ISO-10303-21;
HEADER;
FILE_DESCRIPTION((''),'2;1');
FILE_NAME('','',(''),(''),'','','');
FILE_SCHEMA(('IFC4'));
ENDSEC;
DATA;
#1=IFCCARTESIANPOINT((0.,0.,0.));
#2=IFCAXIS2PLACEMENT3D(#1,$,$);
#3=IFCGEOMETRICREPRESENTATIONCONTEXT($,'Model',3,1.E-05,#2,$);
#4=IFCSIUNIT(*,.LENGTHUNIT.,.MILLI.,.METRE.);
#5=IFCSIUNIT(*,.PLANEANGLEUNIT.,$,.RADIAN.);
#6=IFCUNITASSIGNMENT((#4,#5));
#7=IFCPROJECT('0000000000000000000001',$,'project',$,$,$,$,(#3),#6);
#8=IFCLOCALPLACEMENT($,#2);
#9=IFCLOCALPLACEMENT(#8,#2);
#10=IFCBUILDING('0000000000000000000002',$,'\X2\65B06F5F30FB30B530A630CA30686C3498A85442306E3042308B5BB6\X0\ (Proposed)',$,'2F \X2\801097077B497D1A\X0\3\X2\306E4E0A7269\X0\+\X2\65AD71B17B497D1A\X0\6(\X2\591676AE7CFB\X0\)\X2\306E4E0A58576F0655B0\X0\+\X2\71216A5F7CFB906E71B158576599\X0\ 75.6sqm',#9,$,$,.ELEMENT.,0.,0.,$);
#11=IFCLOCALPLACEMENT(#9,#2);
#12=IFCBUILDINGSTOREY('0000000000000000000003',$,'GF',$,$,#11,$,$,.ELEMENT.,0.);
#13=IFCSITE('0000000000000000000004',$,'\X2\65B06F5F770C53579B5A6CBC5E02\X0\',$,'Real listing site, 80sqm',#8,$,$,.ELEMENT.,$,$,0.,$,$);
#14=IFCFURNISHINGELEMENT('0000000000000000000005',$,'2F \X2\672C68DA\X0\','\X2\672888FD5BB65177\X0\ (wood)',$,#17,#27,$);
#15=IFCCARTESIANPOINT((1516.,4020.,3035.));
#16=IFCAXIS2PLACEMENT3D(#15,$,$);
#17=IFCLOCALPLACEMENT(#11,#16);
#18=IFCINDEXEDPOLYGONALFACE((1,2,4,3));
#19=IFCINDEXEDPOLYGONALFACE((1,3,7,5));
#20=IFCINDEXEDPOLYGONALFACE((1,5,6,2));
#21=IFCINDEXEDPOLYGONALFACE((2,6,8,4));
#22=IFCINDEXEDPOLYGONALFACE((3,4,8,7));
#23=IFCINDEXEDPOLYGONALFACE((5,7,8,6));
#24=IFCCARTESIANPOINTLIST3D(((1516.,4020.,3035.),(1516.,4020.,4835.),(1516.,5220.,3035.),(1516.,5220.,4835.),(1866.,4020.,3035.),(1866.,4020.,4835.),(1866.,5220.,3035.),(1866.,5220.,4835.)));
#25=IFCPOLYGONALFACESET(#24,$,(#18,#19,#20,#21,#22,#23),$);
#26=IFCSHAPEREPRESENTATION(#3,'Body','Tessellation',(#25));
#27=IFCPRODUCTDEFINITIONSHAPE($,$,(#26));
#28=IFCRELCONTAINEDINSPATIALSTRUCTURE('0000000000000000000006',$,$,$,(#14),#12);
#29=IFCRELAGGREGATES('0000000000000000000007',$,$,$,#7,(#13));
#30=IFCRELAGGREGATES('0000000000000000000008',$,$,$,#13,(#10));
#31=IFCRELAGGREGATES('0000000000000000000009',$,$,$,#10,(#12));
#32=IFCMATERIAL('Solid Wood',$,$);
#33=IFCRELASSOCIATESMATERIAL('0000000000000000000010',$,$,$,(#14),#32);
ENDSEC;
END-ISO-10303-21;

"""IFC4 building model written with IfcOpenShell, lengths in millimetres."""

from ifc_helpers import new_model, si_unit, frame, frame_2d, origin, place, context, project, spatial, rectangle, extrude, material, element, save


model = new_model("IFC4")

# Units and contexts
model_context = context("Model", 3, precision=1e-05, world=origin())
ifc_project = project(units=[si_unit("LENGTHUNIT", "METRE", prefix="MILLI"), si_unit("PLANEANGLEUNIT", "RADIAN")], contexts=[model_context])

# Site, building, storey
site_placement = place(None, origin())
site = spatial("IfcSite", under=ifc_project, at=site_placement, Name="新潟県南魚沼市", ObjectType="Real listing site, 80sqm", CompositionType="ELEMENT", RefElevation=0.0)
building_placement = place(site_placement, origin())
building = spatial("IfcBuilding", under=site, at=building_placement, Name="新潟・サウナと水風呂のある家 (Proposed)", ObjectType="2F 耐震等級3の上物+断熱等級6(外皮系)の上塗漆喰+無機系遮熱塗料 75.6sqm", CompositionType="ELEMENT", ElevationOfRefHeight=0.0, ElevationOfTerrain=0.0)
storey_placement = place(building_placement, origin())
storey = spatial("IfcBuildingStorey", under=building, at=storey_placement, Name="GF", CompositionType="ELEMENT", Elevation=0.0)

# Shared definitions
ifc_material_1 = material(Name="Solid Wood")

# Furnishing element
furnishing_placement = place(storey_placement, frame((1516.0, 4020.0, 3035.0)))
element("IfcFurnishingElement", 1, at=furnishing_placement, inside=storey, material=ifc_material_1, Name="2F 本棚", Description="木製家具 (wood)", context=model_context, shape_type="SweptSolid", body=[
    extrude(rectangle(XDim=350.0, YDim=1200.0, at=frame_2d((175.0, 600.0))), frame((1516.0, 4020.0, 3035.0)), (0.0, 0.0, 1.0), 1800.0),
])

save(model, "model.ifc")
